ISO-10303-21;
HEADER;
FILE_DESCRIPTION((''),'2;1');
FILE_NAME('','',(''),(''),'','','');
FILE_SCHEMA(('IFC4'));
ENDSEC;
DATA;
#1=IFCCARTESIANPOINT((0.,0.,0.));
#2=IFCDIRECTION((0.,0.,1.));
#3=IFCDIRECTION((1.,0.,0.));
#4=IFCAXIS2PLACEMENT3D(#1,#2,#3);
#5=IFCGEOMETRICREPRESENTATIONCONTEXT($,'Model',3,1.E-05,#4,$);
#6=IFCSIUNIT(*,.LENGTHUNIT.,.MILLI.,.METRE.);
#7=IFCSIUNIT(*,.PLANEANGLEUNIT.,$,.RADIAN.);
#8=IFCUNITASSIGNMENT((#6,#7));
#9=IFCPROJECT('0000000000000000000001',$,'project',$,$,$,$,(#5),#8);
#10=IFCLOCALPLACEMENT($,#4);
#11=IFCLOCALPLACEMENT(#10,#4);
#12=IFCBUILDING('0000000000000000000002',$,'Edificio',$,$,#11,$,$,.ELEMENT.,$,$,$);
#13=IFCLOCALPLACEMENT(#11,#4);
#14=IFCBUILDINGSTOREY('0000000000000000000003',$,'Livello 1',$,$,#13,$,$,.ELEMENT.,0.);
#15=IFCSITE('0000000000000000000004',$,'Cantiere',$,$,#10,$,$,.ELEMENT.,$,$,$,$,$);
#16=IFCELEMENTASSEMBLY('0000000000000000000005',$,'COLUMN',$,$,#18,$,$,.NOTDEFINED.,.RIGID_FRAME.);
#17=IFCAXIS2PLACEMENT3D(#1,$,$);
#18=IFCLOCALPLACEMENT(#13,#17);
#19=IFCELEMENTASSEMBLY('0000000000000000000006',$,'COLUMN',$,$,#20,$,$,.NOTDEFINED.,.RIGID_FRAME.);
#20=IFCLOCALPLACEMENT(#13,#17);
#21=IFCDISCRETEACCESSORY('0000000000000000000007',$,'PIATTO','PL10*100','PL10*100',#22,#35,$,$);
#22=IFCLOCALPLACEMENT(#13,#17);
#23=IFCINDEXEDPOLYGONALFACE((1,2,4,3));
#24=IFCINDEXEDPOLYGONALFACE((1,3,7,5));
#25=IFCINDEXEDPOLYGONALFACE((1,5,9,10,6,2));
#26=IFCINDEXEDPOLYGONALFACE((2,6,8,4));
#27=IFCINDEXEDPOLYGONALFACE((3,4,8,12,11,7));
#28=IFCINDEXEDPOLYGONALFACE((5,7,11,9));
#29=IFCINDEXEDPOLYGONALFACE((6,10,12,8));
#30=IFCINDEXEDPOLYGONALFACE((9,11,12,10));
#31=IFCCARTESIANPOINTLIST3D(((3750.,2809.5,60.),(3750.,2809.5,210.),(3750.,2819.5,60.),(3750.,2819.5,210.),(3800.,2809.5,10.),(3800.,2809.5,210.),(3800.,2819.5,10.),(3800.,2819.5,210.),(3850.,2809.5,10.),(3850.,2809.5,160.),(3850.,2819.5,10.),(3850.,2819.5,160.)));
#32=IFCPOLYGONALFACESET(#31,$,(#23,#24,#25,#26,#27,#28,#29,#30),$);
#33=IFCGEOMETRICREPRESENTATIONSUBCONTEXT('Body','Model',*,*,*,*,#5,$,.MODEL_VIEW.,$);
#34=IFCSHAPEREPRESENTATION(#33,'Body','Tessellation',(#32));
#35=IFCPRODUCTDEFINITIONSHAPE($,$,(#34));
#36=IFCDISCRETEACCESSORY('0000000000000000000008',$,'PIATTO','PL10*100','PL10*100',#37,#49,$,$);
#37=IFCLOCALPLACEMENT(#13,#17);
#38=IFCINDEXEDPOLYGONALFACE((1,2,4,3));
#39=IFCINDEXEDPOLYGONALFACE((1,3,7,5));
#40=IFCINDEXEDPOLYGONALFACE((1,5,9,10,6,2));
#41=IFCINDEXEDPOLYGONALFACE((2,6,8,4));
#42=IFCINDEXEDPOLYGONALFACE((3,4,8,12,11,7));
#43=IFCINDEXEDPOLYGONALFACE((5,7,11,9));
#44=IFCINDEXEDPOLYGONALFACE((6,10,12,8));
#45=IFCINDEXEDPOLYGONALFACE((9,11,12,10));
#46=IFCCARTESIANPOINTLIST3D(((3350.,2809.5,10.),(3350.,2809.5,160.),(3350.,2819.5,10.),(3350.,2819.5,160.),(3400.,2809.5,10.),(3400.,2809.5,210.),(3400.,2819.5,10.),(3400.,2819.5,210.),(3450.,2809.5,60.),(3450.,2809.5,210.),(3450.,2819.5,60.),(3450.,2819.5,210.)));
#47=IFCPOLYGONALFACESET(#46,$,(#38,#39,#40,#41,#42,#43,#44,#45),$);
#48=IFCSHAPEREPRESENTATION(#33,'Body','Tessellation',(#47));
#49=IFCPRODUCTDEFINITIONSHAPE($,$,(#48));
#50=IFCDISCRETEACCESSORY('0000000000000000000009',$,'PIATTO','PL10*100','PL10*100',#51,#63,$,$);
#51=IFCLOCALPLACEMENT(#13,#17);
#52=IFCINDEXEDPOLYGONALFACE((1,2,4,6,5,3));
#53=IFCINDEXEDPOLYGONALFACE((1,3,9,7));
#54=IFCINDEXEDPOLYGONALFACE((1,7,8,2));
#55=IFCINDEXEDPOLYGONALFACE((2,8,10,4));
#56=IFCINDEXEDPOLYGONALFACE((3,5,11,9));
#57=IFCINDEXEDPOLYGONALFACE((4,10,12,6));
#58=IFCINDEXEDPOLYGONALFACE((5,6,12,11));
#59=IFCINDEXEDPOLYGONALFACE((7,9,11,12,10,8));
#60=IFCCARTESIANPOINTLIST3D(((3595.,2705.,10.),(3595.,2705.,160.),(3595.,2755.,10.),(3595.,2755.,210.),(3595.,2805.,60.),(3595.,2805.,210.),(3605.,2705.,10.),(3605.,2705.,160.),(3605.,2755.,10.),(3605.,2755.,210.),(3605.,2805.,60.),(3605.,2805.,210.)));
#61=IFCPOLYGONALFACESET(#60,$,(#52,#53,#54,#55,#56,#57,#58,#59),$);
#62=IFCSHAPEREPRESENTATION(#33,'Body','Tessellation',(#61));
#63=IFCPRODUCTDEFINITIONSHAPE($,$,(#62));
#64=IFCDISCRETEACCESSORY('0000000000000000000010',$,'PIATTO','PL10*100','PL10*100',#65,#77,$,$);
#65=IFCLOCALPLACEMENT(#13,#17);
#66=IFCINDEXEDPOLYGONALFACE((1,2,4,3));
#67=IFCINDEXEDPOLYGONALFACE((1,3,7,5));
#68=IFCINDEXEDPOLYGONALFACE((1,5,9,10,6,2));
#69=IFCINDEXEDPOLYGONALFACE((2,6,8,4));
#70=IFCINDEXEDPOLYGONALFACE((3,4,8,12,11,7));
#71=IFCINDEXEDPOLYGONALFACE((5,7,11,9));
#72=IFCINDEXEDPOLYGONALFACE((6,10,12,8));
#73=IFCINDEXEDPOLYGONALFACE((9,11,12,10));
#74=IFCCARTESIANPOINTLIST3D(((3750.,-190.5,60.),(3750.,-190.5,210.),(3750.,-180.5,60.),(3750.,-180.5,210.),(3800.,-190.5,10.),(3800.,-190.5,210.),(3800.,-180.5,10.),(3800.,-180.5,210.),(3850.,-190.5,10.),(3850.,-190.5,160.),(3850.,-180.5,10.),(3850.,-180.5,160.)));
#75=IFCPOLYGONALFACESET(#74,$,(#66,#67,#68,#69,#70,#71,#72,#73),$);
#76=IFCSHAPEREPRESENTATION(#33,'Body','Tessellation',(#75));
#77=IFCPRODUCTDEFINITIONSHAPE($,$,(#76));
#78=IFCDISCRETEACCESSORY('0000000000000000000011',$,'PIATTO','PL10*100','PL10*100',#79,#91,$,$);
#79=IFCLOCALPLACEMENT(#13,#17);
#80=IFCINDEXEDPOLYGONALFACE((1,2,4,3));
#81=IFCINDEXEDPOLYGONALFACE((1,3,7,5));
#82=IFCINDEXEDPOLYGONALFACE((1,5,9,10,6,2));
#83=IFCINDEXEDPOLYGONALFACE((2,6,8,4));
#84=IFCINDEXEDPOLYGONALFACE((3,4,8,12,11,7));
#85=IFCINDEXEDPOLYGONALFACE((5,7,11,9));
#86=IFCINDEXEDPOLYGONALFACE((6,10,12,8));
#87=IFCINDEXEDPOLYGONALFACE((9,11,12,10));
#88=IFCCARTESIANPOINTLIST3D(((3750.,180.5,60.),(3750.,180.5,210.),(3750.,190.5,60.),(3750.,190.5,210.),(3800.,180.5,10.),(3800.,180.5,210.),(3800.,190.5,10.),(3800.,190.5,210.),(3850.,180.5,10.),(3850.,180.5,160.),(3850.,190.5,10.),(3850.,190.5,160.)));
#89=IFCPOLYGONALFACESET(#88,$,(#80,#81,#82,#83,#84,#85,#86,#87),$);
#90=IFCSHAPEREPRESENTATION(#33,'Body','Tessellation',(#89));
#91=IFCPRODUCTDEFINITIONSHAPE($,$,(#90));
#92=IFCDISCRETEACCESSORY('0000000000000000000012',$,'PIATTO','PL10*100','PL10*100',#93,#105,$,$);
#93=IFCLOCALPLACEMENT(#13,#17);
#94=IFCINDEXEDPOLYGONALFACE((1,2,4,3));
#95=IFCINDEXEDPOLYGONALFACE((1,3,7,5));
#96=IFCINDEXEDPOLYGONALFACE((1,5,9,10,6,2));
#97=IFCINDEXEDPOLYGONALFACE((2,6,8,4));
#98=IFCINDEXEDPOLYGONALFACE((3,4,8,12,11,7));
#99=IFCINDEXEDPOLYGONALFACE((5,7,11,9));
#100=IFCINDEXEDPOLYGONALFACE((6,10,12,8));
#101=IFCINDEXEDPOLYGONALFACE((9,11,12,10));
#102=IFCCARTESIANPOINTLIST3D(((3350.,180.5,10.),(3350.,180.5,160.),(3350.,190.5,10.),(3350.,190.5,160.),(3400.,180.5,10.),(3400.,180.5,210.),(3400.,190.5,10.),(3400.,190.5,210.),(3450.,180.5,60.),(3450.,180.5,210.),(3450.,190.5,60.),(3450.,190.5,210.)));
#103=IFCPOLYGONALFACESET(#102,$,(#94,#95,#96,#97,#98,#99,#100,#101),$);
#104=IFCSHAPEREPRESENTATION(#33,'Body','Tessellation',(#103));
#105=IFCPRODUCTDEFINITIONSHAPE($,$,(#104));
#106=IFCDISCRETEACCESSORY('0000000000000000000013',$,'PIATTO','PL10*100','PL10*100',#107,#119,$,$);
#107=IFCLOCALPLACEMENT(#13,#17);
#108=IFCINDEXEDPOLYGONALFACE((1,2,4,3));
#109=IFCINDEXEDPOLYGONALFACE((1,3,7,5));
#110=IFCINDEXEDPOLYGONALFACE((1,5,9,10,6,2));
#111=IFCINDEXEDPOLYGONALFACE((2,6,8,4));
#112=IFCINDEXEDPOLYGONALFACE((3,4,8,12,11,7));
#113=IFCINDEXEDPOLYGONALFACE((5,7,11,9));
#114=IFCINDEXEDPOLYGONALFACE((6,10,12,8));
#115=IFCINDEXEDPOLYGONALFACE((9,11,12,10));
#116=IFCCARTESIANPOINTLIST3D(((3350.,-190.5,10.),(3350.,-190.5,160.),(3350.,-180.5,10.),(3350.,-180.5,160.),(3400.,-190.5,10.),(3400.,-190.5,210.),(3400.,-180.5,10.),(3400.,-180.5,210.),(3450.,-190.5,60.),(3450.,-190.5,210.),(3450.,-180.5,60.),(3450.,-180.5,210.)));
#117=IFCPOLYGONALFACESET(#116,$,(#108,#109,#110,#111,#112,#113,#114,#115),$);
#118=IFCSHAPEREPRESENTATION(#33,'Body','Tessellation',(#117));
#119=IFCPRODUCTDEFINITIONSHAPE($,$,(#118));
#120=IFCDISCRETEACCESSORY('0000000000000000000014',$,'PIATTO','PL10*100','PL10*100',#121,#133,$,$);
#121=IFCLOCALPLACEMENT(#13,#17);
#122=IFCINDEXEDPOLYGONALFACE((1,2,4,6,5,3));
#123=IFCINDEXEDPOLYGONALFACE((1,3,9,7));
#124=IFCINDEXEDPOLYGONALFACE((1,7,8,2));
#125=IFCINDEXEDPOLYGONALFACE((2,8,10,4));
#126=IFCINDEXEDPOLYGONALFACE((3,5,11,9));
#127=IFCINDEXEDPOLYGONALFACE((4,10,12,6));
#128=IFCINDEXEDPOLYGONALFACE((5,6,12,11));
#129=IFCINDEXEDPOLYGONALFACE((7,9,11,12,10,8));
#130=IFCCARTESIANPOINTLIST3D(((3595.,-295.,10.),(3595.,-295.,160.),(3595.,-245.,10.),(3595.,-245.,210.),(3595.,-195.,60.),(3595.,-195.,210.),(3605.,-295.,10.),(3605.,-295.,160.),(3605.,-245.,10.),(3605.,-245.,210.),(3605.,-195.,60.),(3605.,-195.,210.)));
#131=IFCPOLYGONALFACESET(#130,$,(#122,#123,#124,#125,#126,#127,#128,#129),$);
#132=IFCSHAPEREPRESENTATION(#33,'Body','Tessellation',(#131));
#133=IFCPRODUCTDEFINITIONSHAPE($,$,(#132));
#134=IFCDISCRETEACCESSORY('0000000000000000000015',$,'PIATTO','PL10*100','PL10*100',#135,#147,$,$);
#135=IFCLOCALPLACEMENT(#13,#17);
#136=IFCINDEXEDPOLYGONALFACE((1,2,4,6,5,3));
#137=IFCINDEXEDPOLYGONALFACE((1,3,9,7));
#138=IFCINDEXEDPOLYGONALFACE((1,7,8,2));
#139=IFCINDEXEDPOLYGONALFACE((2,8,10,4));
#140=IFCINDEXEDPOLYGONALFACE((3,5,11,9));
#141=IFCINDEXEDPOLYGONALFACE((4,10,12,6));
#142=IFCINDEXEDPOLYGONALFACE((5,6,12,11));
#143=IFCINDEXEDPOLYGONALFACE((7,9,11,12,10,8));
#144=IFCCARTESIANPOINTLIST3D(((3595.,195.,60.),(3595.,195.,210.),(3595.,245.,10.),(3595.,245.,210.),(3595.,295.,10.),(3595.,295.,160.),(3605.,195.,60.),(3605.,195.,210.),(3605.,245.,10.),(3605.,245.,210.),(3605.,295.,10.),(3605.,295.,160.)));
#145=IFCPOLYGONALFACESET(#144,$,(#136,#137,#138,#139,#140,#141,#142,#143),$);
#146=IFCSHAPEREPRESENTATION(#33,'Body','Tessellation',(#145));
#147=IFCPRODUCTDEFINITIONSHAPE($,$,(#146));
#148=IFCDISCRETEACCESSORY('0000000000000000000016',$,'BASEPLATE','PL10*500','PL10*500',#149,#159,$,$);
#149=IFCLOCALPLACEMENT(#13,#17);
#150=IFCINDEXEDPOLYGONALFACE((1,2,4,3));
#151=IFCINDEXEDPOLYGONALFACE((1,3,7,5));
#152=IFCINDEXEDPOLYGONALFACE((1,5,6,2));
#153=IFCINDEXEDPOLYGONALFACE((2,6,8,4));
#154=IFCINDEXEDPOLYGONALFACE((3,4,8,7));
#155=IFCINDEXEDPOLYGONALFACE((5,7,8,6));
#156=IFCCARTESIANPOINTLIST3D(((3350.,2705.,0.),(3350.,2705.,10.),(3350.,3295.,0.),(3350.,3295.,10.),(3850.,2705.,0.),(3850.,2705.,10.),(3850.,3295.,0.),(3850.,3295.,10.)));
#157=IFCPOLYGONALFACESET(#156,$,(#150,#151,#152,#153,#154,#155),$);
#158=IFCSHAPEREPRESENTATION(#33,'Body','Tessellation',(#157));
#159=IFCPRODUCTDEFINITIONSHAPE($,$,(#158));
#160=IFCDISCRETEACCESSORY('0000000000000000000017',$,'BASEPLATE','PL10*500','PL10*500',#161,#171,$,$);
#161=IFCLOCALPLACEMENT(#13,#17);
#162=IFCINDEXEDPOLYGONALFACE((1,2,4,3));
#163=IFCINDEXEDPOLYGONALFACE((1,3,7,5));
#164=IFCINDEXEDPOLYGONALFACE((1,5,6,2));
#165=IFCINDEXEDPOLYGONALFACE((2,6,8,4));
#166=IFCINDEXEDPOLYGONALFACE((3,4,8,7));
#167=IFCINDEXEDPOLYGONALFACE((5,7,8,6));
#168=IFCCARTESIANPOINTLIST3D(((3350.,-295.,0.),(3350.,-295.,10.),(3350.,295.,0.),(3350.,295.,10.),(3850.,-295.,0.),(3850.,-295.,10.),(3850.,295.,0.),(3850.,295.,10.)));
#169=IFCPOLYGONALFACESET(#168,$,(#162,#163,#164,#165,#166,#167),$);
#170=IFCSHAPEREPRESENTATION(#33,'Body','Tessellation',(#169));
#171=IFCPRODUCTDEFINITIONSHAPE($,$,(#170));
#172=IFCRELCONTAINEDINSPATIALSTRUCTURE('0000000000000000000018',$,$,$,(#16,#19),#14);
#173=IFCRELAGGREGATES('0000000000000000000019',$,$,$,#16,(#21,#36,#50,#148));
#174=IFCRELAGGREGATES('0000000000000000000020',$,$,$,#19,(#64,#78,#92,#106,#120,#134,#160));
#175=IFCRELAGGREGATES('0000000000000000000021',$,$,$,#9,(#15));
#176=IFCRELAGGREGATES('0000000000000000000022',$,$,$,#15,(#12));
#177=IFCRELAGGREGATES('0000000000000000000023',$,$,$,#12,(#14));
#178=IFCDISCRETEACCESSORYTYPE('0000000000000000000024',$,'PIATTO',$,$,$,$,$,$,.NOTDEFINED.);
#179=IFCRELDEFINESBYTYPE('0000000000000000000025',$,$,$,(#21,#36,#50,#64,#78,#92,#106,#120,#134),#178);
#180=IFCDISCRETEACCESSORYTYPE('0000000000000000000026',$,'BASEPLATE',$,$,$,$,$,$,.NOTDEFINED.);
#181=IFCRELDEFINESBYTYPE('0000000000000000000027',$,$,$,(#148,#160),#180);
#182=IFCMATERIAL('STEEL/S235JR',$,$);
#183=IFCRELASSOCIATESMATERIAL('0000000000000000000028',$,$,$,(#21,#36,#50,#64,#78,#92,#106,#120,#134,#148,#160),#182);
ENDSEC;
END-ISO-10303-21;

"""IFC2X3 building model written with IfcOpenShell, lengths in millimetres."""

from ifc_helpers import new_model, si_unit, frame, origin_with_axes, place, context, subcontext, project, spatial, polyline, outline, extrude, material, type_object, element, aggregate, save


model = new_model("IFC2X3")

# Units and contexts
model_context = context("Model", 3, precision=1e-05, world=origin_with_axes())
body_context = subcontext(model_context, "Body", "Model", "MODEL_VIEW")
ifc_project = project(units=[si_unit("LENGTHUNIT", "METRE", prefix="MILLI"), si_unit("PLANEANGLEUNIT", "RADIAN")], contexts=[model_context])

# Site, building, storey
site_placement = place(None, origin_with_axes())
site = spatial("IfcSite", under=ifc_project, at=site_placement, Name="Cantiere", CompositionType="ELEMENT")
building_placement = place(site_placement, origin_with_axes())
building = spatial("IfcBuilding", under=site, at=building_placement, Name="Edificio", CompositionType="ELEMENT")
storey_placement = place(building_placement, origin_with_axes())
storey = spatial("IfcBuildingStorey", under=building, at=storey_placement, Name="Livello 1", CompositionType="ELEMENT", Elevation=0.0)

# Element assemblies
assembly_1_placement = place(storey_placement, origin_with_axes())
assembly_1 = element("IfcElementAssembly", 1, at=assembly_1_placement, inside=storey, Name="COLUMN", AssemblyPlace="NOTDEFINED", PredefinedType="RIGID_FRAME")
ifc_material_1 = material(Name="STEEL/S235JR")
assembly_2_placement = place(storey_placement, origin_with_axes())
assembly_2 = element("IfcElementAssembly", 2, at=assembly_2_placement, inside=storey, Name="COLUMN", AssemblyPlace="NOTDEFINED", PredefinedType="RIGID_FRAME")

# Shared definitions
discrete_accessory_type_1 = type_object("IfcDiscreteAccessoryType", Name="PIATTO")

# Discrete accessories
discrete_accessory_1_placement = place(assembly_1_placement, frame((3750.0, 2814.5, 60.0), z_axis=(0.0, -1.0, 0.0), x_axis=(0.707107, 0.0, -0.707107)))
discrete_accessory_1 = element("IfcDiscreteAccessory", 3, at=discrete_accessory_1_placement, type_object=discrete_accessory_type_1, material=ifc_material_1, Name="PIATTO", Description="PL10*100", ObjectType="PL10*100", context=body_context, shape_type="SweptSolid", body=[
    extrude(outline(polyline([(0.0, 0.0), (70.7, 0.0), (106.1, 35.4), (0.0, 141.4), (-70.7, 141.4), (-106.1, 106.1), (0.0, 0.0)])), frame((0.0, 0.0, -5.0), z_axis=(0.0, 0.0, 1.0), x_axis=(1.0, 0.0, 0.0)), (0.0, 0.0, 1.0), 10.0),
])
discrete_accessory_2_placement = place(assembly_1_placement, frame((3450.0, 2814.5, 60.0), z_axis=(0.0, 1.0, 0.0), x_axis=(-0.707107, 0.0, -0.707107)))
discrete_accessory_2 = element("IfcDiscreteAccessory", 4, at=discrete_accessory_2_placement, type_object=discrete_accessory_type_1, material=ifc_material_1, Name="PIATTO", Description="PL10*100", ObjectType="PL10*100", context=body_context, shape_type="SweptSolid", body=[
    extrude(outline(polyline([(0.0, 0.0), (70.7, 0.0), (106.1, 35.4), (0.0, 141.4), (-70.7, 141.4), (-106.1, 106.1), (0.0, 0.0)])), frame((0.0, 0.0, -5.0), z_axis=(0.0, 0.0, 1.0), x_axis=(1.0, 0.0, 0.0)), (0.0, 0.0, 1.0), 10.0),
])
discrete_accessory_3_placement = place(assembly_1_placement, frame((3600.0, 2805.0, 60.0), z_axis=(-1.0, 0.0, 0.0), x_axis=(0.0, -0.707107, -0.707107)))
discrete_accessory_3 = element("IfcDiscreteAccessory", 5, at=discrete_accessory_3_placement, type_object=discrete_accessory_type_1, material=ifc_material_1, Name="PIATTO", Description="PL10*100", ObjectType="PL10*100", context=body_context, shape_type="SweptSolid", body=[
    extrude(outline(polyline([(0.0, 0.0), (70.7, 0.0), (106.1, 35.4), (0.0, 141.4), (-70.7, 141.4), (-106.1, 106.1), (0.0, 0.0)])), frame((0.0, 0.0, -5.0), z_axis=(0.0, 0.0, 1.0), x_axis=(1.0, 0.0, 0.0)), (0.0, 0.0, 1.0), 10.0),
])
discrete_accessory_4_placement = place(assembly_2_placement, frame((3750.0, -185.5, 60.0), z_axis=(0.0, -1.0, 0.0), x_axis=(0.707107, 0.0, -0.707107)))
discrete_accessory_4 = element("IfcDiscreteAccessory", 6, at=discrete_accessory_4_placement, type_object=discrete_accessory_type_1, material=ifc_material_1, Name="PIATTO", Description="PL10*100", ObjectType="PL10*100", context=body_context, shape_type="SweptSolid", body=[
    extrude(outline(polyline([(0.0, 0.0), (70.7, 0.0), (106.1, 35.4), (0.0, 141.4), (-70.7, 141.4), (-106.1, 106.1), (0.0, 0.0)])), frame((0.0, 0.0, -5.0), z_axis=(0.0, 0.0, 1.0), x_axis=(1.0, 0.0, 0.0)), (0.0, 0.0, 1.0), 10.0),
])
discrete_accessory_5_placement = place(assembly_2_placement, frame((3750.0, 185.5, 60.0), z_axis=(0.0, -1.0, 0.0), x_axis=(0.707107, 0.0, -0.707107)))
discrete_accessory_5 = element("IfcDiscreteAccessory", 7, at=discrete_accessory_5_placement, type_object=discrete_accessory_type_1, material=ifc_material_1, Name="PIATTO", Description="PL10*100", ObjectType="PL10*100", context=body_context, shape_type="SweptSolid", body=[
    extrude(outline(polyline([(0.0, 0.0), (70.7, 0.0), (106.1, 35.4), (0.0, 141.4), (-70.7, 141.4), (-106.1, 106.1), (0.0, 0.0)])), frame((0.0, 0.0, -5.0), z_axis=(0.0, 0.0, 1.0), x_axis=(1.0, 0.0, 0.0)), (0.0, 0.0, 1.0), 10.0),
])
discrete_accessory_6_placement = place(assembly_2_placement, frame((3450.0, 185.5, 60.0), z_axis=(0.0, 1.0, 0.0), x_axis=(-0.707107, 0.0, -0.707107)))
discrete_accessory_6 = element("IfcDiscreteAccessory", 8, at=discrete_accessory_6_placement, type_object=discrete_accessory_type_1, material=ifc_material_1, Name="PIATTO", Description="PL10*100", ObjectType="PL10*100", context=body_context, shape_type="SweptSolid", body=[
    extrude(outline(polyline([(0.0, 0.0), (70.7, 0.0), (106.1, 35.4), (0.0, 141.4), (-70.7, 141.4), (-106.1, 106.1), (0.0, 0.0)])), frame((0.0, 0.0, -5.0), z_axis=(0.0, 0.0, 1.0), x_axis=(1.0, 0.0, 0.0)), (0.0, 0.0, 1.0), 10.0),
])
discrete_accessory_7_placement = place(assembly_2_placement, frame((3450.0, -185.5, 60.0), z_axis=(0.0, 1.0, 0.0), x_axis=(-0.707107, 0.0, -0.707107)))
discrete_accessory_7 = element("IfcDiscreteAccessory", 9, at=discrete_accessory_7_placement, type_object=discrete_accessory_type_1, material=ifc_material_1, Name="PIATTO", Description="PL10*100", ObjectType="PL10*100", context=body_context, shape_type="SweptSolid", body=[
    extrude(outline(polyline([(0.0, 0.0), (70.7, 0.0), (106.1, 35.4), (0.0, 141.4), (-70.7, 141.4), (-106.1, 106.1), (0.0, 0.0)])), frame((0.0, 0.0, -5.0), z_axis=(0.0, 0.0, 1.0), x_axis=(1.0, 0.0, 0.0)), (0.0, 0.0, 1.0), 10.0),
])
discrete_accessory_8_placement = place(assembly_2_placement, frame((3600.0, -195.0, 60.0), z_axis=(-1.0, 0.0, 0.0), x_axis=(0.0, -0.707107, -0.707107)))
discrete_accessory_8 = element("IfcDiscreteAccessory", 10, at=discrete_accessory_8_placement, type_object=discrete_accessory_type_1, material=ifc_material_1, Name="PIATTO", Description="PL10*100", ObjectType="PL10*100", context=body_context, shape_type="SweptSolid", body=[
    extrude(outline(polyline([(0.0, 0.0), (70.7, 0.0), (106.1, 35.4), (0.0, 141.4), (-70.7, 141.4), (-106.1, 106.1), (0.0, 0.0)])), frame((0.0, 0.0, -5.0), z_axis=(0.0, 0.0, 1.0), x_axis=(1.0, 0.0, 0.0)), (0.0, 0.0, 1.0), 10.0),
])
discrete_accessory_9_placement = place(assembly_2_placement, frame((3600.0, 195.0, 60.0), z_axis=(1.0, 0.0, 0.0), x_axis=(0.0, 0.707107, -0.707107)))
discrete_accessory_9 = element("IfcDiscreteAccessory", 11, at=discrete_accessory_9_placement, type_object=discrete_accessory_type_1, material=ifc_material_1, Name="PIATTO", Description="PL10*100", ObjectType="PL10*100", context=body_context, shape_type="SweptSolid", body=[
    extrude(outline(polyline([(0.0, 0.0), (70.7, 0.0), (106.1, 35.4), (0.0, 141.4), (-70.7, 141.4), (-106.1, 106.1), (0.0, 0.0)])), frame((0.0, 0.0, -5.0), z_axis=(0.0, 0.0, 1.0), x_axis=(1.0, 0.0, 0.0)), (0.0, 0.0, 1.0), 10.0),
])

# Discrete accessories
discrete_accessory_type_2 = type_object("IfcDiscreteAccessoryType", Name="BASEPLATE")
discrete_accessory_10_placement = place(assembly_1_placement, frame((3600.0, 2705.0, 5.0), z_axis=(0.0, 0.0, 1.0), x_axis=(0.0, 1.0, 0.0)))
discrete_accessory_10 = element("IfcDiscreteAccessory", 12, at=discrete_accessory_10_placement, type_object=discrete_accessory_type_2, material=ifc_material_1, Name="BASEPLATE", Description="PL10*500", ObjectType="PL10*500", context=body_context, shape_type="SweptSolid", body=[
    extrude(outline(polyline([(0.0, 250.0), (590.0, 250.0), (590.0, -250.0), (0.0, -250.0), (0.0, 250.0)])), frame((0.0, 0.0, -5.0), z_axis=(0.0, 0.0, 1.0), x_axis=(1.0, 0.0, 0.0)), (0.0, 0.0, 1.0), 10.0),
])
aggregate(assembly_1, [discrete_accessory_1, discrete_accessory_2, discrete_accessory_3, discrete_accessory_10])
discrete_accessory_11_placement = place(assembly_2_placement, frame((3600.0, -295.0, 5.0), z_axis=(0.0, 0.0, 1.0), x_axis=(0.0, 1.0, 0.0)))
discrete_accessory_11 = element("IfcDiscreteAccessory", 13, at=discrete_accessory_11_placement, type_object=discrete_accessory_type_2, material=ifc_material_1, Name="BASEPLATE", Description="PL10*500", ObjectType="PL10*500", context=body_context, shape_type="SweptSolid", body=[
    extrude(outline(polyline([(0.0, 250.0), (590.0, 250.0), (590.0, -250.0), (0.0, -250.0), (0.0, 250.0)])), frame((0.0, 0.0, -5.0), z_axis=(0.0, 0.0, 1.0), x_axis=(1.0, 0.0, 0.0)), (0.0, 0.0, 1.0), 10.0),
])
aggregate(assembly_2, [discrete_accessory_4, discrete_accessory_5, discrete_accessory_6, discrete_accessory_7, discrete_accessory_8, discrete_accessory_9, discrete_accessory_11])

save(model, "model.ifc")
